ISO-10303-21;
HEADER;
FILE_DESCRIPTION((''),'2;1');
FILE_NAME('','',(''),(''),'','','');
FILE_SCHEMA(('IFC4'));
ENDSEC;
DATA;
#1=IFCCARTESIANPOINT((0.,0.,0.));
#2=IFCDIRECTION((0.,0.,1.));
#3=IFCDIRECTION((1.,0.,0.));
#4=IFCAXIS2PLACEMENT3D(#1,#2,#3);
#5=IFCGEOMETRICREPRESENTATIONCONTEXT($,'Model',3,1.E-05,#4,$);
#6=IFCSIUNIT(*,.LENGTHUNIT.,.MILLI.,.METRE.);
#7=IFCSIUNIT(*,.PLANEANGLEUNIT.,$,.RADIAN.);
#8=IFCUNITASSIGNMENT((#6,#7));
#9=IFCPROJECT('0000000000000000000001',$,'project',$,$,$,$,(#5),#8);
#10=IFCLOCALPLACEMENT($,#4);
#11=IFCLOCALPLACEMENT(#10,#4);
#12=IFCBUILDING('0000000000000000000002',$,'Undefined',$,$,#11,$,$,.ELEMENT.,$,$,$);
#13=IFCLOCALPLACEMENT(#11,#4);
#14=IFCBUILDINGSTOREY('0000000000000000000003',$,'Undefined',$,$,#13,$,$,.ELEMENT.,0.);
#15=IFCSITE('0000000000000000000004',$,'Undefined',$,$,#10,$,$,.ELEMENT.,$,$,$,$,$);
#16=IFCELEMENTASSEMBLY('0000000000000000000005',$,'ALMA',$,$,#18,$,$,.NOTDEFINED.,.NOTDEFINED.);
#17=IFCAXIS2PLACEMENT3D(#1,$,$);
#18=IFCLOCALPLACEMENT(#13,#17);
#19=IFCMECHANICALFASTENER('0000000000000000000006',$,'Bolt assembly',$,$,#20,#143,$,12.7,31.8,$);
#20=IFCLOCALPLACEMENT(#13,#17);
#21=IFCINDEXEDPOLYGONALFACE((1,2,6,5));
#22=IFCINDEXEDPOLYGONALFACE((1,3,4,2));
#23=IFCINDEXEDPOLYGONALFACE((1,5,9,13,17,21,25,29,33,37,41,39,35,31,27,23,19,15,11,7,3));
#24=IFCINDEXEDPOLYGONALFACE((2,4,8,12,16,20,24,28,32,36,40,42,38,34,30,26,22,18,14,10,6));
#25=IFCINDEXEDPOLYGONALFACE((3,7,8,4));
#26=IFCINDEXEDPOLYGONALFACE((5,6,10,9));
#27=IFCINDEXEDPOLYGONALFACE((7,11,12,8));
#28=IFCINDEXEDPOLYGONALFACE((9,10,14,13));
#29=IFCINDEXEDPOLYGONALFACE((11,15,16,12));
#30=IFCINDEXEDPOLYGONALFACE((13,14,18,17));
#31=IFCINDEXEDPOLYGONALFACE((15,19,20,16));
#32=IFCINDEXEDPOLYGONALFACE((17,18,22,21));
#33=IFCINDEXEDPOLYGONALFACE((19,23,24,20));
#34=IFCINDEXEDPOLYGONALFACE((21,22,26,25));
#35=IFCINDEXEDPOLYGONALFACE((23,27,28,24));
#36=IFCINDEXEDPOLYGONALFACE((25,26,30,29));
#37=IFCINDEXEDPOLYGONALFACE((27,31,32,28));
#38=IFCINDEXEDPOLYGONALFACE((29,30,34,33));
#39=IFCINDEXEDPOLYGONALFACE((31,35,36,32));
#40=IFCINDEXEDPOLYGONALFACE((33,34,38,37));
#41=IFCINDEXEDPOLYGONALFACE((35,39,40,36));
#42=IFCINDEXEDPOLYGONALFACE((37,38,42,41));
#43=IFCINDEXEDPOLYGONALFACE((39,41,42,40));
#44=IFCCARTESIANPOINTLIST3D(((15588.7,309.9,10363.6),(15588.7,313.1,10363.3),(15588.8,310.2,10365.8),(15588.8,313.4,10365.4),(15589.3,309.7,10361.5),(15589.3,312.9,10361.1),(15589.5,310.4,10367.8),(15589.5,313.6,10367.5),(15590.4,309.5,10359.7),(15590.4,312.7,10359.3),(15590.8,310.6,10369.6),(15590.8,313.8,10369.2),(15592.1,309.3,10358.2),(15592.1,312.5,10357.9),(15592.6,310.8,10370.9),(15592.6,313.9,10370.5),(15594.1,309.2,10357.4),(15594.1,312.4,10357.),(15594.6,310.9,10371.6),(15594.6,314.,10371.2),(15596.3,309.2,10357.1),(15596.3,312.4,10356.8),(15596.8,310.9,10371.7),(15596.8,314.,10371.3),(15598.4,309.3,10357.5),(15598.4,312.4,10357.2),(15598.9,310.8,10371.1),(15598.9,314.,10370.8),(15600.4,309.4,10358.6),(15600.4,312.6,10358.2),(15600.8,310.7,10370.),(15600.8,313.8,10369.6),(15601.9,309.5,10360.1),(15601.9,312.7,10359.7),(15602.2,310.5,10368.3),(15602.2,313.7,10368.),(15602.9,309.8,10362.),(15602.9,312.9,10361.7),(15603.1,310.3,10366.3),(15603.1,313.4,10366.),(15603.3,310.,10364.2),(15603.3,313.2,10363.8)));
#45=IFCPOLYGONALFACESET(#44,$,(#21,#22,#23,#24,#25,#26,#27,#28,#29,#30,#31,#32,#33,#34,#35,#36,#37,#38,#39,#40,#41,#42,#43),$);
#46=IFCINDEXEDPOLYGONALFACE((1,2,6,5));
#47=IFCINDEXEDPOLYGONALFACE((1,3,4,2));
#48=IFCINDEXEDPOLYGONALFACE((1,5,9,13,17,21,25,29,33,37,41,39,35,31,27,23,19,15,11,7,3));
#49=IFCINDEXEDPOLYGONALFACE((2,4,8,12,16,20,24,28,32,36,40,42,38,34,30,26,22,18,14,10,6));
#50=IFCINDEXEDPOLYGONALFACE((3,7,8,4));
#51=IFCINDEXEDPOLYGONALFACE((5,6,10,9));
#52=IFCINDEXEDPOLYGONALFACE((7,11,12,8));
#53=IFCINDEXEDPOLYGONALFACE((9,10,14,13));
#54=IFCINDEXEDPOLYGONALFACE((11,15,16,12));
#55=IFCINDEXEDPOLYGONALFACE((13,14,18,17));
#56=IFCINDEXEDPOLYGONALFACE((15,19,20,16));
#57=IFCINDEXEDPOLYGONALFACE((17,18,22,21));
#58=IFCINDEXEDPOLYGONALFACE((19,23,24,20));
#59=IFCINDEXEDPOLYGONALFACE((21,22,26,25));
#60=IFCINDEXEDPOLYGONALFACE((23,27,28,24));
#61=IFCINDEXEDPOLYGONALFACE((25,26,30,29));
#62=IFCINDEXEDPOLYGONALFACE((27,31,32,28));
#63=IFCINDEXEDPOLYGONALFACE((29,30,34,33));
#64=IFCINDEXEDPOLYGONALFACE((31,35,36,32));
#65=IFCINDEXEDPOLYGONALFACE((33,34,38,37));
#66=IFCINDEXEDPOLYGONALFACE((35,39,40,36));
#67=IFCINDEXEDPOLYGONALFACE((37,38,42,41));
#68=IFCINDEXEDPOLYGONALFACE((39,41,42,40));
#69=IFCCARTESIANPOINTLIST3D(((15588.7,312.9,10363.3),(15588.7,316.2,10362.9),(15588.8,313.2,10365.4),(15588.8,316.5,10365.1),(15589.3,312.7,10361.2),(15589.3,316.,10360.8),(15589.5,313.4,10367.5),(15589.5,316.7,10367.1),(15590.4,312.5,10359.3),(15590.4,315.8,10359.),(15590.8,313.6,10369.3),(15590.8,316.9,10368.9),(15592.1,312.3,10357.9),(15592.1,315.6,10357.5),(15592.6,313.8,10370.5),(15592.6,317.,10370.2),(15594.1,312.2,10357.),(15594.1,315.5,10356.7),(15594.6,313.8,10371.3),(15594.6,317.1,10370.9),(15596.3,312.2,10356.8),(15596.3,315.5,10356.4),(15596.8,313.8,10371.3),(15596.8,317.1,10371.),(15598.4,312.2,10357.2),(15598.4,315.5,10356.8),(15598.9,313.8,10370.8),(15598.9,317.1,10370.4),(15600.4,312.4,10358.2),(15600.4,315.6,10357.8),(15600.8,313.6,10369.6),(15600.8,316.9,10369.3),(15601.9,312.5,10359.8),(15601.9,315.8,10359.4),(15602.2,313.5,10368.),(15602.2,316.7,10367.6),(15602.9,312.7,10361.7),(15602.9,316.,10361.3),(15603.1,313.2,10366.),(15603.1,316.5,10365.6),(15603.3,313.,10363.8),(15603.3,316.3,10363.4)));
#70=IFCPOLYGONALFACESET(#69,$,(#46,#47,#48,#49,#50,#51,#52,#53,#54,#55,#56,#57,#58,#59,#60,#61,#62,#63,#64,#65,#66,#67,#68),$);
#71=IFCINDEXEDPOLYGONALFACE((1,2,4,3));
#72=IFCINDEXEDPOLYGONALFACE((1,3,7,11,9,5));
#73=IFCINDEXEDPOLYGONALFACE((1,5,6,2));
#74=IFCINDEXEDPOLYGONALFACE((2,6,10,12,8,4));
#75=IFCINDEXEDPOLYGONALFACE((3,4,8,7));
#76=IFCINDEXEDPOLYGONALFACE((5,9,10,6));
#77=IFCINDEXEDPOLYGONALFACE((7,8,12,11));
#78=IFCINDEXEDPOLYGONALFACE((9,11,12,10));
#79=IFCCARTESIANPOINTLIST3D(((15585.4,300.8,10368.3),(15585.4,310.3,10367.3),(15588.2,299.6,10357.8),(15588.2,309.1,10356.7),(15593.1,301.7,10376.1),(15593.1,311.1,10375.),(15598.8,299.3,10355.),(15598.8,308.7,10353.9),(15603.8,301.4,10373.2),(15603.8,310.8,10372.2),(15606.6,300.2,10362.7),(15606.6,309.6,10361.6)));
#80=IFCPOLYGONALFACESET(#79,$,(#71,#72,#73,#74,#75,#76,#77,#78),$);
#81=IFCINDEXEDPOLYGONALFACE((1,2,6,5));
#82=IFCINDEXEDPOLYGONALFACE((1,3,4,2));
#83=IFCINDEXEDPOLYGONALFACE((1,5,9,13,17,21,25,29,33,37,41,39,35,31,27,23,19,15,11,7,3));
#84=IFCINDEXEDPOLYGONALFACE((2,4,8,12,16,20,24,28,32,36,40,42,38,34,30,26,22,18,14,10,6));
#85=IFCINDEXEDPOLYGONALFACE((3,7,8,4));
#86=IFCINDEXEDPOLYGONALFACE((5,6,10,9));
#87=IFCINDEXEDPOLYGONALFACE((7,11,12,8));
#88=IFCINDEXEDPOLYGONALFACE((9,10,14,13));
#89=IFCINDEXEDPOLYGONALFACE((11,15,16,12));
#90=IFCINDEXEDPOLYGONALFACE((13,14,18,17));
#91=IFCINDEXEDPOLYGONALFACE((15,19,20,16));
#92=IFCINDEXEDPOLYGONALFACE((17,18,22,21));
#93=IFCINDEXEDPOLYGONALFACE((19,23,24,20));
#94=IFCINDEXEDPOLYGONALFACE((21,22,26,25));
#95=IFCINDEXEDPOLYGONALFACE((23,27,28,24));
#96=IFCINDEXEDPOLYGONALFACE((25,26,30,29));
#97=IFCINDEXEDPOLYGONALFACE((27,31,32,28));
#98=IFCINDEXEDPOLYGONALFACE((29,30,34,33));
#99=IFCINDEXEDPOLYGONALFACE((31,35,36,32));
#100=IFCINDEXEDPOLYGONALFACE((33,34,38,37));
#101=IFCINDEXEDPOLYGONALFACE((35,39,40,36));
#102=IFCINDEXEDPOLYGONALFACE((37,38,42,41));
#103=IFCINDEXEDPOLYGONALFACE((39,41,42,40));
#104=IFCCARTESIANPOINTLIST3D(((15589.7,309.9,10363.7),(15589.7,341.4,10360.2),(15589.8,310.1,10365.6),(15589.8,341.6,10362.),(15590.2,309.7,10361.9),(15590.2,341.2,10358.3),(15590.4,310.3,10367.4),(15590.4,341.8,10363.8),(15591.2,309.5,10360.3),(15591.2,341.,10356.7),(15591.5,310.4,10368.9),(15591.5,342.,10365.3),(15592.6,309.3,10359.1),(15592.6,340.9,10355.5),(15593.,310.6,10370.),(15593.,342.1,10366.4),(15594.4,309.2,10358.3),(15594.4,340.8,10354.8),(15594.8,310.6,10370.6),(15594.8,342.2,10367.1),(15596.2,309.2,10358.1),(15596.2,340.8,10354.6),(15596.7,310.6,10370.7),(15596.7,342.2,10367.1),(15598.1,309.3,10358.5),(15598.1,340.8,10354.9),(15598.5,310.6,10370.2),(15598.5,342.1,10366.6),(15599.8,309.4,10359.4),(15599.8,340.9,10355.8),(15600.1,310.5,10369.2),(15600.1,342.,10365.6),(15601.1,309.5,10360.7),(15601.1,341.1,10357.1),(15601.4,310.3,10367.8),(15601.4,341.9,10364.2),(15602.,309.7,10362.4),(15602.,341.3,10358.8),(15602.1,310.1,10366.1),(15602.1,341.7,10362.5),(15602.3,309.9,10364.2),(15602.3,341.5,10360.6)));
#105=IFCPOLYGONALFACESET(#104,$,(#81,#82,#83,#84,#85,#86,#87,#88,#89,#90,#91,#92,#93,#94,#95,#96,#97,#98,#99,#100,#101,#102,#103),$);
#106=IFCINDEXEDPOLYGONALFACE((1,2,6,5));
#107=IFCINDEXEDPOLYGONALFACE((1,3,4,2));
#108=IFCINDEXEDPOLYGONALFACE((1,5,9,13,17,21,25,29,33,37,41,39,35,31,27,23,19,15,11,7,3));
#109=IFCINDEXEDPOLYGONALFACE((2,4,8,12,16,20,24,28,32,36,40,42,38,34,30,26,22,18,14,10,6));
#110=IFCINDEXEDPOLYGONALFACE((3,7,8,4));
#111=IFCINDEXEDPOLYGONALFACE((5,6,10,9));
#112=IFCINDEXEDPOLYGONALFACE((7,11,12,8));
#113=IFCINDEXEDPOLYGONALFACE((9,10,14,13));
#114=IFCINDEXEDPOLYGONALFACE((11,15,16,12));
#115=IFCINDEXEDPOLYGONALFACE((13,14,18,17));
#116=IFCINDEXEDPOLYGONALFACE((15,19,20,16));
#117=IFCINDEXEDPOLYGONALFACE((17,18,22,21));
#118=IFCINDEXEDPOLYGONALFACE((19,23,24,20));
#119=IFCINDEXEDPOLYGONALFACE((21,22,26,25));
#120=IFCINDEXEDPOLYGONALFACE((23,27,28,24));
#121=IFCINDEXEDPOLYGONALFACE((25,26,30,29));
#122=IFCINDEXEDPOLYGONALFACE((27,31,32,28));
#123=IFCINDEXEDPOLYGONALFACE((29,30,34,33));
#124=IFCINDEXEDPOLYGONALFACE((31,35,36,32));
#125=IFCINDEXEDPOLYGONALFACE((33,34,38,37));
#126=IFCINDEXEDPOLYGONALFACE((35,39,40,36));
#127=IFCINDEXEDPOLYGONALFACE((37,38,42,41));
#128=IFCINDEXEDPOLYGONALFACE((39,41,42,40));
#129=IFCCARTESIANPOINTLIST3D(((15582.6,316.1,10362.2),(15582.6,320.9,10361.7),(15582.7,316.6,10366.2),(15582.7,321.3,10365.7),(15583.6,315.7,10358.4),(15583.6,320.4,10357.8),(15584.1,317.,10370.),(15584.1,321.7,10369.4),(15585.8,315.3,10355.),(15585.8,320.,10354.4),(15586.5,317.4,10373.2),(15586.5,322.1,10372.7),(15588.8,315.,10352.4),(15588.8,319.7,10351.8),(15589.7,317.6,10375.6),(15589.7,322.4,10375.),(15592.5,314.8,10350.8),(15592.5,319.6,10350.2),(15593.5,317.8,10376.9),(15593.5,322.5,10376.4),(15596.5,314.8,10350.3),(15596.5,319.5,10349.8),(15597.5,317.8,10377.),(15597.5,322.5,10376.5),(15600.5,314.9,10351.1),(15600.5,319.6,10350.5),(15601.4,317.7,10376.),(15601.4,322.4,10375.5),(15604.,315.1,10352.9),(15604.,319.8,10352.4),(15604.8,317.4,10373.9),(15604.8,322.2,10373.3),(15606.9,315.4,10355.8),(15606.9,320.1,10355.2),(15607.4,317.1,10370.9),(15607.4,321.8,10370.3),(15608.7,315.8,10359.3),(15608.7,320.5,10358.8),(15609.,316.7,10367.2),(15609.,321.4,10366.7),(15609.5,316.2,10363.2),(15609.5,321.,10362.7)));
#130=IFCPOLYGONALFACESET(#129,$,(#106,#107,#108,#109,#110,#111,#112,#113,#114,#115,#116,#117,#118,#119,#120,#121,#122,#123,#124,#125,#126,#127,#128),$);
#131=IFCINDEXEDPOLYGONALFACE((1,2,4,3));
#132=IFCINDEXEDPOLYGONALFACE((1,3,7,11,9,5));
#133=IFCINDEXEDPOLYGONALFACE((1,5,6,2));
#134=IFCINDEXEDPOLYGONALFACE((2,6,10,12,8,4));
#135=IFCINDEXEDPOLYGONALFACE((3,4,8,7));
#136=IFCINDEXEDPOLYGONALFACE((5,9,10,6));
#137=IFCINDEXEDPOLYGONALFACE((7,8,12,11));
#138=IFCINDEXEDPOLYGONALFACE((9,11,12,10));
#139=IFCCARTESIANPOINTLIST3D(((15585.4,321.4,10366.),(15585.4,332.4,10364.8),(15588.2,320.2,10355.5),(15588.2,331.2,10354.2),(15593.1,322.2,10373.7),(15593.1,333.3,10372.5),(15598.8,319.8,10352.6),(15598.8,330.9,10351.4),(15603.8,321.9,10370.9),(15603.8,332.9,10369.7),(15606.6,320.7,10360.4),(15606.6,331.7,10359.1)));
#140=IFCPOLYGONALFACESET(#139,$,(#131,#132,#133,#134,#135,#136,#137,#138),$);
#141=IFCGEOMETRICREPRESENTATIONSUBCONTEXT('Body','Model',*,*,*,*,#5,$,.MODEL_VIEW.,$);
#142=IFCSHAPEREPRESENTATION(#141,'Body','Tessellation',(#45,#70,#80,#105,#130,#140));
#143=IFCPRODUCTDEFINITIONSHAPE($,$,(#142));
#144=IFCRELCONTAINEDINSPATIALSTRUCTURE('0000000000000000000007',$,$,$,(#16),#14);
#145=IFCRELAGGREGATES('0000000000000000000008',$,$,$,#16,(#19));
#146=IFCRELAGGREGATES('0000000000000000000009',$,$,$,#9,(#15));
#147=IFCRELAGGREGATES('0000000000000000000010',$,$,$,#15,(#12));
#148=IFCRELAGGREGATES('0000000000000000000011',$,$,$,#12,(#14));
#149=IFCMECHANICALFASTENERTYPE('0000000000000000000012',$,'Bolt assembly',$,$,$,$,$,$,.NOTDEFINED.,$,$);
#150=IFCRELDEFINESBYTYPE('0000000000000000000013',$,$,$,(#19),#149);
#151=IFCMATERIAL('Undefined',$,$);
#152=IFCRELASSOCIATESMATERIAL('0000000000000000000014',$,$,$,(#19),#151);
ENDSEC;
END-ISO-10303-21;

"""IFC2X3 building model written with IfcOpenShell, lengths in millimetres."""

from ifc_helpers import new_model, si_unit, frame, origin_with_axes, origin_2d_with_axis, place, context, subcontext, project, spatial, polyline, circle, outline, extrude, source, transform, mapped, material, type_object, element, aggregate, save


model = new_model("IFC2X3")

# Units and contexts
model_context = context("Model", 3, precision=1e-05, world=origin_with_axes())
body_context = subcontext(model_context, "Body", "Model", "MODEL_VIEW")
ifc_project = project(units=[si_unit("LENGTHUNIT", "METRE", prefix="MILLI"), si_unit("PLANEANGLEUNIT", "RADIAN")], contexts=[model_context])

# Site, building, storey
site_placement = place(None, origin_with_axes())
site = spatial("IfcSite", under=ifc_project, at=site_placement, Name="Undefined", CompositionType="ELEMENT")
building_placement = place(site_placement, origin_with_axes())
building = spatial("IfcBuilding", under=site, at=building_placement, Name="Undefined", CompositionType="ELEMENT")
storey_placement = place(building_placement, origin_with_axes())
storey = spatial("IfcBuildingStorey", under=building, at=storey_placement, Name="Undefined", CompositionType="ELEMENT", Elevation=0.0)

# Element assembly
assembly_1_placement = place(storey_placement, origin_with_axes())
assembly_1 = element("IfcElementAssembly", 1, at=assembly_1_placement, inside=storey, Name="ALMA", AssemblyPlace="NOTDEFINED", PredefinedType="NOTDEFINED")

# Mechanical fastener
ifc_material_1 = material(Name="Undefined")
mechanical_fastener_type = type_object("IfcMechanicalFastenerType", Name="Bolt assembly")
shared_shape_1 = source(origin_with_axes(), body_context, "Body", "SweptSolid", [
    extrude(circle(Radius=7.3, at=origin_2d_with_axis()), frame((0.0, 0.1, 0.0), z_axis=(0.0, 1.0, 0.0), x_axis=(1.0, 0.0, 0.0)), (0.0, 0.0, 1.0), 3.2),
    extrude(circle(Radius=7.3, at=origin_2d_with_axis()), frame((0.0, 3.1, 0.0), z_axis=(0.0, 1.0, 0.0), x_axis=(1.0, 0.0, 0.0)), (0.0, 0.0, 1.0), 3.3),
    extrude(outline(polyline([(9.5, -5.5), (9.5, 5.5), (0.0, 11.0), (-9.5, 5.5), (-9.5, -5.5), (0.0, -11.0), (9.5, -5.5)])), frame((0.0, -9.5, 0.0), z_axis=(0.0, 1.0, 0.0), x_axis=(1.0, 0.0, 0.0)), (0.0, 0.0, 1.0), 9.5),
    extrude(circle(Radius=6.3, at=origin_2d_with_axis()), frame((0.0, 0.0, 0.0), z_axis=(0.0, 1.0, 0.0), x_axis=(1.0, 0.0, 0.0)), (0.0, 0.0, 1.0), 31.8),
    extrude(circle(Radius=13.5, at=origin_2d_with_axis()), frame((0.0, 6.4, 0.0), z_axis=(0.0, 1.0, 0.0), x_axis=(1.0, 0.0, 0.0)), (0.0, 0.0, 1.0), 4.8),
    extrude(outline(polyline([(9.5, -5.5), (9.5, 5.5), (0.0, 11.0), (-9.5, 5.5), (-9.5, -5.5), (0.0, -11.0), (9.5, -5.5)])), frame((0.0, 11.2, 0.0), z_axis=(0.0, 1.0, 0.0), x_axis=(1.0, 0.0, 0.0)), (0.0, 0.0, 1.0), 11.1),
])
mechanical_fastener_1_placement = place(assembly_1_placement, frame((15596.0, 309.9, 10364.4), z_axis=(-0.707107, -0.079651, -0.702606), x_axis=(-0.707107, 0.079651, 0.702606)))
mechanical_fastener_1 = element("IfcMechanicalFastener", 2, at=mechanical_fastener_1_placement, type_object=mechanical_fastener_type, material=ifc_material_1, Name="Bolt assembly", NominalDiameter=12.7, NominalLength=31.8, context=body_context, shape_type="MappedRepresentation", body=[
    mapped(shared_shape_1, transform((0.0, 0.0, 0.0))),
])

aggregate(assembly_1, [mechanical_fastener_1])

save(model, "model.ifc")
